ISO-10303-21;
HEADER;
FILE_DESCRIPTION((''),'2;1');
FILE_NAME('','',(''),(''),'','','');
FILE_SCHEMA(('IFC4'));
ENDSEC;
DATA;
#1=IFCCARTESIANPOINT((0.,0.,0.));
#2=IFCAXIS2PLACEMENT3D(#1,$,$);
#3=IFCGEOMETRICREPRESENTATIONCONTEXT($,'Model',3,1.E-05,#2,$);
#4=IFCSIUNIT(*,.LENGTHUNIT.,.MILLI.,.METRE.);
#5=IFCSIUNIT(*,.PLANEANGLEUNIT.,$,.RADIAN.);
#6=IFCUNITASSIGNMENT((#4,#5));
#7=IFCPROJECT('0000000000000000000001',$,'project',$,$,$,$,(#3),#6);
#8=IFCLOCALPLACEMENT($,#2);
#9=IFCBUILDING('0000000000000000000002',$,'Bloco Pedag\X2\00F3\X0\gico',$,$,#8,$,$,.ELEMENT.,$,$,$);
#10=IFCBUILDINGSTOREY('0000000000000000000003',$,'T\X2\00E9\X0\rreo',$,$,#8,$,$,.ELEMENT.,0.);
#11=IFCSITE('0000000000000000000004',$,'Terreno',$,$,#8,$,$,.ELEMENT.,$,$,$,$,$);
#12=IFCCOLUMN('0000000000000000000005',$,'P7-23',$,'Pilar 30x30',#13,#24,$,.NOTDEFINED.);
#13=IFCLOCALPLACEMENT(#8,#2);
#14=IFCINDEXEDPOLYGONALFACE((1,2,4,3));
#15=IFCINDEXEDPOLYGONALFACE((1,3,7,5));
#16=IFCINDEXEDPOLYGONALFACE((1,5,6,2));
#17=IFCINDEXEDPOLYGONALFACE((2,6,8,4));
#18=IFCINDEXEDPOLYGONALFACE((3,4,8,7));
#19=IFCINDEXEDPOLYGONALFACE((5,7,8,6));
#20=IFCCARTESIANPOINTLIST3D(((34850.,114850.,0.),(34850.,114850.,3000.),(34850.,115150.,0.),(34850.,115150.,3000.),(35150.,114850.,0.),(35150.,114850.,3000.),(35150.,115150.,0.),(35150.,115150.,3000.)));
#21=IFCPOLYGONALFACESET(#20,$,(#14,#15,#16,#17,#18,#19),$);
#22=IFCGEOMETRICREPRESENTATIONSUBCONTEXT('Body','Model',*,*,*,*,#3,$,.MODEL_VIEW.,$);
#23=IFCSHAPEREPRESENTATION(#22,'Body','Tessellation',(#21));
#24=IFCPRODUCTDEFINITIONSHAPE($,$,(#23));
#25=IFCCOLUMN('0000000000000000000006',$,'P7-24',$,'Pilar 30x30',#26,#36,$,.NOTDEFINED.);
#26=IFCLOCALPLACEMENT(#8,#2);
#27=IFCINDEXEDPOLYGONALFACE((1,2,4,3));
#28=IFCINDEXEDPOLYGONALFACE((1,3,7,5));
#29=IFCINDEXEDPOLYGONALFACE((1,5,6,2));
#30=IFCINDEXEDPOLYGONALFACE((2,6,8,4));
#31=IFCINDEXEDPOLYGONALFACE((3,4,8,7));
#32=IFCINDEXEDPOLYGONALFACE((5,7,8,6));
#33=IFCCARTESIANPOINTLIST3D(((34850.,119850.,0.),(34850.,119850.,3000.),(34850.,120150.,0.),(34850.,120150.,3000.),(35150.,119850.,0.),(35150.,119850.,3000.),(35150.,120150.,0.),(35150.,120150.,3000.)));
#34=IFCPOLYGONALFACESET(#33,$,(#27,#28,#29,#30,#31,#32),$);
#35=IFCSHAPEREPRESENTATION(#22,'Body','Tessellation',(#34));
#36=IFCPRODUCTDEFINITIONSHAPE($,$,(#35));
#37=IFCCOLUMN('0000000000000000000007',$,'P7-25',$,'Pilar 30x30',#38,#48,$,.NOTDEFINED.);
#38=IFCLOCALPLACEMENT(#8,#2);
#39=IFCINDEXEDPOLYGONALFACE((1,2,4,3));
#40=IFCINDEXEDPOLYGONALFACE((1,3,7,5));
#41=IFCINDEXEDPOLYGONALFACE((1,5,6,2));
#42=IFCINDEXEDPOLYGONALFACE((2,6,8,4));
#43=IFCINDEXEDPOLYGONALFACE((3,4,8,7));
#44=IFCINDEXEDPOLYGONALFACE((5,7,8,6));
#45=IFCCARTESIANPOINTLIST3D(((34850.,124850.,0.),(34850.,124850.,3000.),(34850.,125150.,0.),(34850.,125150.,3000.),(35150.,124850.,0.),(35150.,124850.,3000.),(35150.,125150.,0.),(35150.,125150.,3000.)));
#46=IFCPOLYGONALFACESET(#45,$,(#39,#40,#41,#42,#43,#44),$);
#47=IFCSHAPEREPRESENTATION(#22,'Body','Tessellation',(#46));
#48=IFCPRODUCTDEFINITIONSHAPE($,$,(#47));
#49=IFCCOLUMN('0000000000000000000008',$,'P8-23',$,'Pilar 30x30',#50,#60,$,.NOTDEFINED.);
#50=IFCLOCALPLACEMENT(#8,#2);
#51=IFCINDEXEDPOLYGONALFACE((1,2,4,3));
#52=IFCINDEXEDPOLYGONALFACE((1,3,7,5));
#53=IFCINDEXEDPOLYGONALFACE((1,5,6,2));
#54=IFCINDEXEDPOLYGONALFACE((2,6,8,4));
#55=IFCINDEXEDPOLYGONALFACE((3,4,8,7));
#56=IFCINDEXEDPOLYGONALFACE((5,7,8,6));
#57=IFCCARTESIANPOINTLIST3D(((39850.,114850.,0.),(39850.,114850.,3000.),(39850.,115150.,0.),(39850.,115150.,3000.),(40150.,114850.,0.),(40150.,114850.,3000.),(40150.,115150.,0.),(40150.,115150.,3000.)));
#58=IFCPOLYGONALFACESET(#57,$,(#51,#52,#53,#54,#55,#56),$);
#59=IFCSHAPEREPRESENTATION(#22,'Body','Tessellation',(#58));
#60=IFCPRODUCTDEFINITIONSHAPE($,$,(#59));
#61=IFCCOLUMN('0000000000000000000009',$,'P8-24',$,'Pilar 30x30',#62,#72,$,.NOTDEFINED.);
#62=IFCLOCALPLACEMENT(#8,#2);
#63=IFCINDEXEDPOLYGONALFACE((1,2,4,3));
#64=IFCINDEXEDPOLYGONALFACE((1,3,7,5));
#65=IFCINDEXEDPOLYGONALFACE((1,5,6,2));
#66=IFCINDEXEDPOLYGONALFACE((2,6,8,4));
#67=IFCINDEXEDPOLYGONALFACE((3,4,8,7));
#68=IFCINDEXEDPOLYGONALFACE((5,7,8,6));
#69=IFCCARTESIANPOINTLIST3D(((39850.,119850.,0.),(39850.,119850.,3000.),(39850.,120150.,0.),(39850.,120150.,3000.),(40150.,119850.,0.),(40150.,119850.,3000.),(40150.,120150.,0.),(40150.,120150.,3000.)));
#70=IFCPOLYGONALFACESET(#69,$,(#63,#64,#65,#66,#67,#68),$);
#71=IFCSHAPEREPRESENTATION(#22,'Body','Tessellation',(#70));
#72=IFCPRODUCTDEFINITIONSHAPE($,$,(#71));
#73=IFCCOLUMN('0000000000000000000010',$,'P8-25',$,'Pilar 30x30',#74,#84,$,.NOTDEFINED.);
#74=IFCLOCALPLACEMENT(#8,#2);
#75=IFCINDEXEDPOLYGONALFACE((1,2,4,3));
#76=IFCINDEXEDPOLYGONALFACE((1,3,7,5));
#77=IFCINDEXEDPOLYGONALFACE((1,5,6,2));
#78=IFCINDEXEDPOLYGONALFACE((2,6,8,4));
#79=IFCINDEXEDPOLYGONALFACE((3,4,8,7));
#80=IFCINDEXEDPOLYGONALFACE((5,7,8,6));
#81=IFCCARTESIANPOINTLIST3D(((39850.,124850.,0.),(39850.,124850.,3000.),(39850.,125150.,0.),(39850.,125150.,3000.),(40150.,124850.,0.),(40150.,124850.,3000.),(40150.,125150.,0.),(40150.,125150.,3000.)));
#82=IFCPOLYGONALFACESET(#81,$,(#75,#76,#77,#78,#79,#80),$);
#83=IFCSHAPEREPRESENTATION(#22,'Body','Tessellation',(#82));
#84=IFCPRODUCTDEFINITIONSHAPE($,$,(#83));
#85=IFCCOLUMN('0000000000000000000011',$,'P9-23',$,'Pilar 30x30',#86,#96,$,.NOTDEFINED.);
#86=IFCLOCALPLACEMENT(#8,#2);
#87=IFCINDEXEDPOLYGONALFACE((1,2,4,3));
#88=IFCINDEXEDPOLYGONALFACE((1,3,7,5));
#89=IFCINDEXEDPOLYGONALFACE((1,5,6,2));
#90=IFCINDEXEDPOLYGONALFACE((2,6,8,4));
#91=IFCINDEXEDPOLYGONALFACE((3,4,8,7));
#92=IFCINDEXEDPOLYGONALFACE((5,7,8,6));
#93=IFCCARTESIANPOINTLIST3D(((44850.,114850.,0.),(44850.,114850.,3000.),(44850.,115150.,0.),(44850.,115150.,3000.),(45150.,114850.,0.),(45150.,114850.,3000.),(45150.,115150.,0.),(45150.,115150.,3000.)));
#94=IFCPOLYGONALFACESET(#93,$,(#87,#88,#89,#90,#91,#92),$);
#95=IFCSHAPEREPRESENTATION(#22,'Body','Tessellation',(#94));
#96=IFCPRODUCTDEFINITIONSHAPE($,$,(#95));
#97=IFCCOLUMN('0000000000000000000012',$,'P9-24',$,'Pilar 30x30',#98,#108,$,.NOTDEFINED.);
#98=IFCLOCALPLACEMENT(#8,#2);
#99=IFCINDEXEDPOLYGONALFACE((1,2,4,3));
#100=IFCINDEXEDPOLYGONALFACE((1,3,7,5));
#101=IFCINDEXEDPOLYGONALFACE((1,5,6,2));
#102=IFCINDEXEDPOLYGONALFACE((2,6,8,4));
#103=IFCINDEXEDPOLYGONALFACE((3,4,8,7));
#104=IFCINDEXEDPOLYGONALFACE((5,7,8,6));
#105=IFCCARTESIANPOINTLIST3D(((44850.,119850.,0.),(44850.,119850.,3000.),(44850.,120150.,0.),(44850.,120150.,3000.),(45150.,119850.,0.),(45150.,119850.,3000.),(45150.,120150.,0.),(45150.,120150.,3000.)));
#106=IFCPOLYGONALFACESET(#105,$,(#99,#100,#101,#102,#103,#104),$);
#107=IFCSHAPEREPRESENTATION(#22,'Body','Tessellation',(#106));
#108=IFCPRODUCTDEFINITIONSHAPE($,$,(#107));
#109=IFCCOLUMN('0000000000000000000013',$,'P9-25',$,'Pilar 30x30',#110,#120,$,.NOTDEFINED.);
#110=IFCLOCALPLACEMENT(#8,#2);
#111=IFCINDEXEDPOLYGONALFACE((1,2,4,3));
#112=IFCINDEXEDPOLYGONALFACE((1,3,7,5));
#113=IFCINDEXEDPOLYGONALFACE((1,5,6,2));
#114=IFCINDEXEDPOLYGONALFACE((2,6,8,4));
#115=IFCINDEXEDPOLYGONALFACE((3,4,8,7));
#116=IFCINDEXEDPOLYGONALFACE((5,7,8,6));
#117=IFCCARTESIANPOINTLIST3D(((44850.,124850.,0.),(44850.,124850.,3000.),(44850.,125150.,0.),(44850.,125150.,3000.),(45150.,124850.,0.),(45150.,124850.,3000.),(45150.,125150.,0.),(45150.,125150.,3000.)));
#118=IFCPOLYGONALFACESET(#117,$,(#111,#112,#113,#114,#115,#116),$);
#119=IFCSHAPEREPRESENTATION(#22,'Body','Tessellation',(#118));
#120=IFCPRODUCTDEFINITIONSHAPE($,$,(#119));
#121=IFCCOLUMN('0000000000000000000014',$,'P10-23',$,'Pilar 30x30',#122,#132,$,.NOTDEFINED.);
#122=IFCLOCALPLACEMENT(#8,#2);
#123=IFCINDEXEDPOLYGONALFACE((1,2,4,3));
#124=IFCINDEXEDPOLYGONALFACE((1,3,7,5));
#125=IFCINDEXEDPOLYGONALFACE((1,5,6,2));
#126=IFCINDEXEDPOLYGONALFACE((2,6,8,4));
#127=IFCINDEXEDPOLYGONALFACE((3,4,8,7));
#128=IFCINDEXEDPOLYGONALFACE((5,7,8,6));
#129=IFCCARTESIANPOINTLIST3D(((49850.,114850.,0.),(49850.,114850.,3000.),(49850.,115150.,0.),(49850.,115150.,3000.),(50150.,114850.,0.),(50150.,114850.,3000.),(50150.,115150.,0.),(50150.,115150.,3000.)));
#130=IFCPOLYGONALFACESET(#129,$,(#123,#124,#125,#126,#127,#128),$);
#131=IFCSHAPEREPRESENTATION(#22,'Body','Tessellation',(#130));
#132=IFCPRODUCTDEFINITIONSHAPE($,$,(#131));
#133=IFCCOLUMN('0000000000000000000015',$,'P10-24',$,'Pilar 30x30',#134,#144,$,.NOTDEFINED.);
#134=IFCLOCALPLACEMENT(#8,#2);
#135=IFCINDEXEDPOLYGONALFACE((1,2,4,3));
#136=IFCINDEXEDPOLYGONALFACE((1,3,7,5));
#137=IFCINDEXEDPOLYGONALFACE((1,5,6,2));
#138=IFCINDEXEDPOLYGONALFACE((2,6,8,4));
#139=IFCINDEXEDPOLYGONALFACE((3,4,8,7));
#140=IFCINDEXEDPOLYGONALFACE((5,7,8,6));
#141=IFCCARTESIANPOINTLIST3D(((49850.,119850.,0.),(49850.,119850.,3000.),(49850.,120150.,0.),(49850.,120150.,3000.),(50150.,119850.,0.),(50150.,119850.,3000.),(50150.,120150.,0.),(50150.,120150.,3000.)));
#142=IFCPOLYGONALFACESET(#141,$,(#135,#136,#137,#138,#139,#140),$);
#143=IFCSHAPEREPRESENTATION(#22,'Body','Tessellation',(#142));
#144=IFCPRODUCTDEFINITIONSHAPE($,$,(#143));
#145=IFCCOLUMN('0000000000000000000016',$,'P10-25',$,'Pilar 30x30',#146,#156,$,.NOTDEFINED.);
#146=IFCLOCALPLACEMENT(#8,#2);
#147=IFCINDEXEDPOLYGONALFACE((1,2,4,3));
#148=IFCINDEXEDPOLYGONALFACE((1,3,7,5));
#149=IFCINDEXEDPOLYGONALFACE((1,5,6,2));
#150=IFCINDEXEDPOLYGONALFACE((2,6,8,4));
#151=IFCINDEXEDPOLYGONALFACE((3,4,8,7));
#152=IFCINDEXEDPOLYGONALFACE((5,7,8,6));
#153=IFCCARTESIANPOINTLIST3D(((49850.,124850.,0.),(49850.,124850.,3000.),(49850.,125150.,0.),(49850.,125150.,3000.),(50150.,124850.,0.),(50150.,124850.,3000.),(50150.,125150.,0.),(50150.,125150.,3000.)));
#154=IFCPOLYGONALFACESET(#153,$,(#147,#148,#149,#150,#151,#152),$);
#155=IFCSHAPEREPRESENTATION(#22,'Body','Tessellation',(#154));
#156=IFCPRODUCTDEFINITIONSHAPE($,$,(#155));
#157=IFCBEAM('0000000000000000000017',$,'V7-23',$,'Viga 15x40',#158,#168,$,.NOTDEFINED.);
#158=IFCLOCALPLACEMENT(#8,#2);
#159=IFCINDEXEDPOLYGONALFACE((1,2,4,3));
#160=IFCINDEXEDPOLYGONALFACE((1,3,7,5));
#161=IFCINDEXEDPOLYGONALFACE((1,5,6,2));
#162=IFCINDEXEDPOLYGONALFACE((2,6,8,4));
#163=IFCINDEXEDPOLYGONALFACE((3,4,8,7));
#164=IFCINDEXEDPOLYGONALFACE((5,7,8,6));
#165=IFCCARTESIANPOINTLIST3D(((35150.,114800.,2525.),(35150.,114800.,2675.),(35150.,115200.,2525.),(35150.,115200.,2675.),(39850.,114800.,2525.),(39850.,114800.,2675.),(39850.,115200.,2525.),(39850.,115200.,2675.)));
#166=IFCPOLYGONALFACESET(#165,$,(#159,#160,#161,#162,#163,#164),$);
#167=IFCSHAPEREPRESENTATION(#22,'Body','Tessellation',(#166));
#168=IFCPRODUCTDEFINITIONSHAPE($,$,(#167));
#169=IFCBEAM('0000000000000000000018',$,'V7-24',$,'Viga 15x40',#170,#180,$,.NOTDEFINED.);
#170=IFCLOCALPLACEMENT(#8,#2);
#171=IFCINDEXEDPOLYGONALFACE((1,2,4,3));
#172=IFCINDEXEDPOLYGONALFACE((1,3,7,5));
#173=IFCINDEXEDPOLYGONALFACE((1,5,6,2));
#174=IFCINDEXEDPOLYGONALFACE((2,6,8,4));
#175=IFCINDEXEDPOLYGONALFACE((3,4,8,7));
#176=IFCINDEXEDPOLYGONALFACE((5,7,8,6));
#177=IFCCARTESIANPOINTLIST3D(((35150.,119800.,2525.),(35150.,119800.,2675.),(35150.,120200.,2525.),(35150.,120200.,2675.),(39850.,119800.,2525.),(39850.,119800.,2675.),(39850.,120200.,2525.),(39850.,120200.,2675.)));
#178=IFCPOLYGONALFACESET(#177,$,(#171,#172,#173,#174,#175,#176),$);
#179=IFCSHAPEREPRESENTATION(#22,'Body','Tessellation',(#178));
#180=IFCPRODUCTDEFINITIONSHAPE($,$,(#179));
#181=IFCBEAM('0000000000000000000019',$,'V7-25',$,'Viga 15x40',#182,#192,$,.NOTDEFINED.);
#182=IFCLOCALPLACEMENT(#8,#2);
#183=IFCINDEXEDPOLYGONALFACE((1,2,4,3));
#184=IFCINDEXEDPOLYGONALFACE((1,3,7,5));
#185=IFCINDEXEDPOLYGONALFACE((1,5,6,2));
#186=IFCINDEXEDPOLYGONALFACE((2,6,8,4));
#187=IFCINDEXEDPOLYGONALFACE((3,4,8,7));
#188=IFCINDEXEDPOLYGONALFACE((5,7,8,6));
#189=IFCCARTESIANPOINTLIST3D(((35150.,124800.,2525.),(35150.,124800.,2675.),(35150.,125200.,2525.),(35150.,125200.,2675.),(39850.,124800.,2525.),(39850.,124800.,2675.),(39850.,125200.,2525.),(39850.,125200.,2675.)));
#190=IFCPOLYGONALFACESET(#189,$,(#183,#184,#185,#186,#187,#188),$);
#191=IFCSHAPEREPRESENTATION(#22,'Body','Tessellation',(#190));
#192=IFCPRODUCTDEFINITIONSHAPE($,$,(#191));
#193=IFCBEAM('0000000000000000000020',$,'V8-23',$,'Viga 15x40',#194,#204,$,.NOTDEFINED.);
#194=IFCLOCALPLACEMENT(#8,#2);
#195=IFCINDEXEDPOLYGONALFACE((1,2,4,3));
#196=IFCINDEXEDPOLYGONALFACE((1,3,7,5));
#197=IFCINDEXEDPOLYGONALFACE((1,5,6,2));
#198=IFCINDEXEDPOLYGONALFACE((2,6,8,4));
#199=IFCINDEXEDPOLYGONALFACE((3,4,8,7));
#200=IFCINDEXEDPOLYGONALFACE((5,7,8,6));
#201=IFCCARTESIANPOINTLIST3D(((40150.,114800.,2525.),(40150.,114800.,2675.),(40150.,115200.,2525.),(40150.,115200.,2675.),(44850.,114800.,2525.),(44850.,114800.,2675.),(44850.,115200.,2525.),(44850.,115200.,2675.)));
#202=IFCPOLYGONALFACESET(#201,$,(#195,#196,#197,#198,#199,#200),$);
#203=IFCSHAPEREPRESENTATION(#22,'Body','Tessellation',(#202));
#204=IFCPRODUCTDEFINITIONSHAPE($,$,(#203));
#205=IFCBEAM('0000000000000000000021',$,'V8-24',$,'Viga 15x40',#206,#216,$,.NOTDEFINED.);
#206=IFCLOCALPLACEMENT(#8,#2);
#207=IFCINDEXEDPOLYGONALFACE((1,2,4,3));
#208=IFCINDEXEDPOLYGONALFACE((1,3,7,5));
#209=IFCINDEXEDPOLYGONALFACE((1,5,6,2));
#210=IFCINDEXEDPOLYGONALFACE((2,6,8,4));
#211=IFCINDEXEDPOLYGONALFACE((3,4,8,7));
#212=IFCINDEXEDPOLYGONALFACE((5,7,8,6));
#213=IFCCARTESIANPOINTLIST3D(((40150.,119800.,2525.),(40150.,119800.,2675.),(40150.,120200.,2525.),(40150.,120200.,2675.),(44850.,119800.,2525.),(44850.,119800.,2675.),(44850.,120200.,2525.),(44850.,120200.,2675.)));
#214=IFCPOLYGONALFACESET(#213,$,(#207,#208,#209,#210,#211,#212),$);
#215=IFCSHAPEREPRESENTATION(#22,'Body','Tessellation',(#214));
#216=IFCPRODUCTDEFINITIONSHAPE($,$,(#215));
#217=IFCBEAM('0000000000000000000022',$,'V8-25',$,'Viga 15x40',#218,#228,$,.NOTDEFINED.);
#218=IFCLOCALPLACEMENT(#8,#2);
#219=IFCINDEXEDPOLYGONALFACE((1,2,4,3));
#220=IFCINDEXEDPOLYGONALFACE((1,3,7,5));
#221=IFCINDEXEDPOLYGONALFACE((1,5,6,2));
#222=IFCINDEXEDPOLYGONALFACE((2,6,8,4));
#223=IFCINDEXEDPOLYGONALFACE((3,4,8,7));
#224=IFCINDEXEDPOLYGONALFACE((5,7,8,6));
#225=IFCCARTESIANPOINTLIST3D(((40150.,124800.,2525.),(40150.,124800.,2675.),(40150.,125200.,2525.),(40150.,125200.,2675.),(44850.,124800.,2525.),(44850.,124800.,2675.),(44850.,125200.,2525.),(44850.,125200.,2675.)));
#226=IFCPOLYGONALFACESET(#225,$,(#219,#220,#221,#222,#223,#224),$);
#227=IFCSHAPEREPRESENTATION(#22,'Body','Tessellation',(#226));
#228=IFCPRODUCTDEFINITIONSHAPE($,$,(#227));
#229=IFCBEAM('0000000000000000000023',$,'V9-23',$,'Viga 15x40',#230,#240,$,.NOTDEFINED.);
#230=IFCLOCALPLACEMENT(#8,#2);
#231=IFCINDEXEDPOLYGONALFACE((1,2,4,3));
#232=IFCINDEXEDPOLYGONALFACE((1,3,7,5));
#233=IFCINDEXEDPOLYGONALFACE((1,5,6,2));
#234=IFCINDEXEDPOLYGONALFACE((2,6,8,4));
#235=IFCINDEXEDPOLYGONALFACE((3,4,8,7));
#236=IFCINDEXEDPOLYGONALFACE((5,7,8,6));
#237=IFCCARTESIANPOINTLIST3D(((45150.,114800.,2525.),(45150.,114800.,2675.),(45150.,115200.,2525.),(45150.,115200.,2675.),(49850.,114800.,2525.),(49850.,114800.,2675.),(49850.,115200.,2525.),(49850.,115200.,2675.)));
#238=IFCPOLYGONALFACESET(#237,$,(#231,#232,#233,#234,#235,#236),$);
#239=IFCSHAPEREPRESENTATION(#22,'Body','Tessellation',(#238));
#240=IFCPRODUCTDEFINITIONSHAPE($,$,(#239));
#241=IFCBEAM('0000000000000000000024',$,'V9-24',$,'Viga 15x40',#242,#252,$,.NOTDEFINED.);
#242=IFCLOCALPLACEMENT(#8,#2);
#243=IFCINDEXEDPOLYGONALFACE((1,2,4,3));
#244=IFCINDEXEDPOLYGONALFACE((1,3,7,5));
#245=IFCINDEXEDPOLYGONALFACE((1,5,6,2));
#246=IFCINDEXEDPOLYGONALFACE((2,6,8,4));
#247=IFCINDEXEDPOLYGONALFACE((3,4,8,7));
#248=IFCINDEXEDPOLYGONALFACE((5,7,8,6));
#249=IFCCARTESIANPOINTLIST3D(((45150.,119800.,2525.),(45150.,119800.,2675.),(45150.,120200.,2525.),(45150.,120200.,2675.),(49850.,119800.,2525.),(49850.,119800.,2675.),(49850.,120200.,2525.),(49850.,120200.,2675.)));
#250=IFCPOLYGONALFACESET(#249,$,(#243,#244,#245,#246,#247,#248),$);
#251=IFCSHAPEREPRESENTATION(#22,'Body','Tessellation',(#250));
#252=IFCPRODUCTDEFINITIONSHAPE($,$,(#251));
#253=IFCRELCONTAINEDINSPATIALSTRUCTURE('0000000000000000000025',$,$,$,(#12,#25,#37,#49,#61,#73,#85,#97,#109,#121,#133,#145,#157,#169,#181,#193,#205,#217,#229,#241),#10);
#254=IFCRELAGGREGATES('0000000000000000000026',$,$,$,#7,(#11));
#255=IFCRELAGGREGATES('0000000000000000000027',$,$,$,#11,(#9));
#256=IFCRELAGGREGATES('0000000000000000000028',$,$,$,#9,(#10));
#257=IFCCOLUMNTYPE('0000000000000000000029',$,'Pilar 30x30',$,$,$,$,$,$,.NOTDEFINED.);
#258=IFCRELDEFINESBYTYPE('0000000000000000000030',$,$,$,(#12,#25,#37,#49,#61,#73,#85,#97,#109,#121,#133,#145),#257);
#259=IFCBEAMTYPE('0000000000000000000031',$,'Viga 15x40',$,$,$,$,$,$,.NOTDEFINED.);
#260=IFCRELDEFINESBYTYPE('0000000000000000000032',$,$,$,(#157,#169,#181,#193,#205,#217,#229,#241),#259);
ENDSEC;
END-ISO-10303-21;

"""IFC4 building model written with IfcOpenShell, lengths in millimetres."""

from ifc_helpers import new_model, si_unit, frame, origin, origin_2d, place, context, subcontext, project, spatial, rectangle, extrude, type_object, element, save


model = new_model("IFC4")

# Units and contexts
model_context = context("Model", 3, precision=1e-05, world=origin())
body_context = subcontext(model_context, "Body", "Model", "MODEL_VIEW")
ifc_project = project(units=[si_unit("LENGTHUNIT", "METRE", prefix="MILLI"), si_unit("PLANEANGLEUNIT", "RADIAN")], contexts=[model_context])

# Site, building, storey
placement = place(None, origin())
site = spatial("IfcSite", under=ifc_project, at=placement, Name="Terreno", CompositionType="ELEMENT")
building = spatial("IfcBuilding", under=site, at=placement, Name="Bloco Pedagógico", CompositionType="ELEMENT")
storey = spatial("IfcBuildingStorey", under=building, at=placement, Name="Térreo", CompositionType="ELEMENT", Elevation=0.0)

# Columns
column_type = type_object("IfcColumnType", Name="Pilar 30x30", PredefinedType="NOTDEFINED")
for number, where, z_axis, x_axis, name in (
    (1, (35000.0, 115000.0, 0.0), (0.0, 0.0, 1.0), (1.0, 0.0, 0.0), "P7-23"),
    (2, (35000.0, 120000.0, 0.0), (0.0, 0.0, 1.0), (1.0, 0.0, 0.0), "P7-24"),
    (3, (35000.0, 125000.0, 0.0), (0.0, 0.0, 1.0), (1.0, 0.0, 0.0), "P7-25"),
    (4, (40000.0, 115000.0, 0.0), (0.0, 0.0, 1.0), (1.0, 0.0, 0.0), "P8-23"),
    (5, (40000.0, 120000.0, 0.0), (0.0, 0.0, 1.0), (1.0, 0.0, 0.0), "P8-24"),
    (6, (40000.0, 125000.0, 0.0), (0.0, 0.0, 1.0), (1.0, 0.0, 0.0), "P8-25"),
    (7, (45000.0, 115000.0, 0.0), (0.0, 0.0, 1.0), (1.0, 0.0, 0.0), "P9-23"),
    (8, (45000.0, 120000.0, 0.0), (0.0, 0.0, 1.0), (1.0, 0.0, 0.0), "P9-24"),
    (9, (45000.0, 125000.0, 0.0), (0.0, 0.0, 1.0), (1.0, 0.0, 0.0), "P9-25"),
    (10, (50000.0, 115000.0, 0.0), (0.0, 0.0, 1.0), (1.0, 0.0, 0.0), "P10-23"),
    (11, (50000.0, 120000.0, 0.0), (0.0, 0.0, 1.0), (1.0, 0.0, 0.0), "P10-24"),
    (12, (50000.0, 125000.0, 0.0), (0.0, 0.0, 1.0), (1.0, 0.0, 0.0), "P10-25"),
):
    element("IfcColumn", number, at=place(None, frame(where, z_axis=z_axis, x_axis=x_axis)), inside=storey, type_object=column_type, Name=name, ObjectType="Pilar 30x30", PredefinedType="NOTDEFINED", context=body_context, shape_type="SweptSolid", body=[
        extrude(rectangle(XDim=300.0, YDim=300.0, at=origin_2d()), None, (0.0, 0.0, 1.0), 3000.0),
    ])

# Beams
beam_type = type_object("IfcBeamType", Name="Viga 15x40", PredefinedType="NOTDEFINED")
for number, where, z_axis, x_axis, name in (
    (13, (35150.0, 115000.0, 2600.0), (1.0, 0.0, 0.0), (0.0, 1.0, 0.0), "V7-23"),
    (14, (35150.0, 120000.0, 2600.0), (1.0, 0.0, 0.0), (0.0, 1.0, 0.0), "V7-24"),
    (15, (35150.0, 125000.0, 2600.0), (1.0, 0.0, 0.0), (0.0, 1.0, 0.0), "V7-25"),
    (16, (40150.0, 115000.0, 2600.0), (1.0, 0.0, 0.0), (0.0, 1.0, 0.0), "V8-23"),
    (17, (40150.0, 120000.0, 2600.0), (1.0, 0.0, 0.0), (0.0, 1.0, 0.0), "V8-24"),
    (18, (40150.0, 125000.0, 2600.0), (1.0, 0.0, 0.0), (0.0, 1.0, 0.0), "V8-25"),
    (19, (45150.0, 115000.0, 2600.0), (1.0, 0.0, 0.0), (0.0, 1.0, 0.0), "V9-23"),
    (20, (45150.0, 120000.0, 2600.0), (1.0, 0.0, 0.0), (0.0, 1.0, 0.0), "V9-24"),
):
    element("IfcBeam", number, at=place(None, frame(where, z_axis=z_axis, x_axis=x_axis)), inside=storey, type_object=beam_type, Name=name, ObjectType="Viga 15x40", PredefinedType="NOTDEFINED", context=body_context, shape_type="SweptSolid", body=[
        extrude(rectangle(XDim=400.0, YDim=150.0, at=origin_2d()), None, (0.0, 0.0, 1.0), 4700.0),
    ])

save(model, "model.ifc")
